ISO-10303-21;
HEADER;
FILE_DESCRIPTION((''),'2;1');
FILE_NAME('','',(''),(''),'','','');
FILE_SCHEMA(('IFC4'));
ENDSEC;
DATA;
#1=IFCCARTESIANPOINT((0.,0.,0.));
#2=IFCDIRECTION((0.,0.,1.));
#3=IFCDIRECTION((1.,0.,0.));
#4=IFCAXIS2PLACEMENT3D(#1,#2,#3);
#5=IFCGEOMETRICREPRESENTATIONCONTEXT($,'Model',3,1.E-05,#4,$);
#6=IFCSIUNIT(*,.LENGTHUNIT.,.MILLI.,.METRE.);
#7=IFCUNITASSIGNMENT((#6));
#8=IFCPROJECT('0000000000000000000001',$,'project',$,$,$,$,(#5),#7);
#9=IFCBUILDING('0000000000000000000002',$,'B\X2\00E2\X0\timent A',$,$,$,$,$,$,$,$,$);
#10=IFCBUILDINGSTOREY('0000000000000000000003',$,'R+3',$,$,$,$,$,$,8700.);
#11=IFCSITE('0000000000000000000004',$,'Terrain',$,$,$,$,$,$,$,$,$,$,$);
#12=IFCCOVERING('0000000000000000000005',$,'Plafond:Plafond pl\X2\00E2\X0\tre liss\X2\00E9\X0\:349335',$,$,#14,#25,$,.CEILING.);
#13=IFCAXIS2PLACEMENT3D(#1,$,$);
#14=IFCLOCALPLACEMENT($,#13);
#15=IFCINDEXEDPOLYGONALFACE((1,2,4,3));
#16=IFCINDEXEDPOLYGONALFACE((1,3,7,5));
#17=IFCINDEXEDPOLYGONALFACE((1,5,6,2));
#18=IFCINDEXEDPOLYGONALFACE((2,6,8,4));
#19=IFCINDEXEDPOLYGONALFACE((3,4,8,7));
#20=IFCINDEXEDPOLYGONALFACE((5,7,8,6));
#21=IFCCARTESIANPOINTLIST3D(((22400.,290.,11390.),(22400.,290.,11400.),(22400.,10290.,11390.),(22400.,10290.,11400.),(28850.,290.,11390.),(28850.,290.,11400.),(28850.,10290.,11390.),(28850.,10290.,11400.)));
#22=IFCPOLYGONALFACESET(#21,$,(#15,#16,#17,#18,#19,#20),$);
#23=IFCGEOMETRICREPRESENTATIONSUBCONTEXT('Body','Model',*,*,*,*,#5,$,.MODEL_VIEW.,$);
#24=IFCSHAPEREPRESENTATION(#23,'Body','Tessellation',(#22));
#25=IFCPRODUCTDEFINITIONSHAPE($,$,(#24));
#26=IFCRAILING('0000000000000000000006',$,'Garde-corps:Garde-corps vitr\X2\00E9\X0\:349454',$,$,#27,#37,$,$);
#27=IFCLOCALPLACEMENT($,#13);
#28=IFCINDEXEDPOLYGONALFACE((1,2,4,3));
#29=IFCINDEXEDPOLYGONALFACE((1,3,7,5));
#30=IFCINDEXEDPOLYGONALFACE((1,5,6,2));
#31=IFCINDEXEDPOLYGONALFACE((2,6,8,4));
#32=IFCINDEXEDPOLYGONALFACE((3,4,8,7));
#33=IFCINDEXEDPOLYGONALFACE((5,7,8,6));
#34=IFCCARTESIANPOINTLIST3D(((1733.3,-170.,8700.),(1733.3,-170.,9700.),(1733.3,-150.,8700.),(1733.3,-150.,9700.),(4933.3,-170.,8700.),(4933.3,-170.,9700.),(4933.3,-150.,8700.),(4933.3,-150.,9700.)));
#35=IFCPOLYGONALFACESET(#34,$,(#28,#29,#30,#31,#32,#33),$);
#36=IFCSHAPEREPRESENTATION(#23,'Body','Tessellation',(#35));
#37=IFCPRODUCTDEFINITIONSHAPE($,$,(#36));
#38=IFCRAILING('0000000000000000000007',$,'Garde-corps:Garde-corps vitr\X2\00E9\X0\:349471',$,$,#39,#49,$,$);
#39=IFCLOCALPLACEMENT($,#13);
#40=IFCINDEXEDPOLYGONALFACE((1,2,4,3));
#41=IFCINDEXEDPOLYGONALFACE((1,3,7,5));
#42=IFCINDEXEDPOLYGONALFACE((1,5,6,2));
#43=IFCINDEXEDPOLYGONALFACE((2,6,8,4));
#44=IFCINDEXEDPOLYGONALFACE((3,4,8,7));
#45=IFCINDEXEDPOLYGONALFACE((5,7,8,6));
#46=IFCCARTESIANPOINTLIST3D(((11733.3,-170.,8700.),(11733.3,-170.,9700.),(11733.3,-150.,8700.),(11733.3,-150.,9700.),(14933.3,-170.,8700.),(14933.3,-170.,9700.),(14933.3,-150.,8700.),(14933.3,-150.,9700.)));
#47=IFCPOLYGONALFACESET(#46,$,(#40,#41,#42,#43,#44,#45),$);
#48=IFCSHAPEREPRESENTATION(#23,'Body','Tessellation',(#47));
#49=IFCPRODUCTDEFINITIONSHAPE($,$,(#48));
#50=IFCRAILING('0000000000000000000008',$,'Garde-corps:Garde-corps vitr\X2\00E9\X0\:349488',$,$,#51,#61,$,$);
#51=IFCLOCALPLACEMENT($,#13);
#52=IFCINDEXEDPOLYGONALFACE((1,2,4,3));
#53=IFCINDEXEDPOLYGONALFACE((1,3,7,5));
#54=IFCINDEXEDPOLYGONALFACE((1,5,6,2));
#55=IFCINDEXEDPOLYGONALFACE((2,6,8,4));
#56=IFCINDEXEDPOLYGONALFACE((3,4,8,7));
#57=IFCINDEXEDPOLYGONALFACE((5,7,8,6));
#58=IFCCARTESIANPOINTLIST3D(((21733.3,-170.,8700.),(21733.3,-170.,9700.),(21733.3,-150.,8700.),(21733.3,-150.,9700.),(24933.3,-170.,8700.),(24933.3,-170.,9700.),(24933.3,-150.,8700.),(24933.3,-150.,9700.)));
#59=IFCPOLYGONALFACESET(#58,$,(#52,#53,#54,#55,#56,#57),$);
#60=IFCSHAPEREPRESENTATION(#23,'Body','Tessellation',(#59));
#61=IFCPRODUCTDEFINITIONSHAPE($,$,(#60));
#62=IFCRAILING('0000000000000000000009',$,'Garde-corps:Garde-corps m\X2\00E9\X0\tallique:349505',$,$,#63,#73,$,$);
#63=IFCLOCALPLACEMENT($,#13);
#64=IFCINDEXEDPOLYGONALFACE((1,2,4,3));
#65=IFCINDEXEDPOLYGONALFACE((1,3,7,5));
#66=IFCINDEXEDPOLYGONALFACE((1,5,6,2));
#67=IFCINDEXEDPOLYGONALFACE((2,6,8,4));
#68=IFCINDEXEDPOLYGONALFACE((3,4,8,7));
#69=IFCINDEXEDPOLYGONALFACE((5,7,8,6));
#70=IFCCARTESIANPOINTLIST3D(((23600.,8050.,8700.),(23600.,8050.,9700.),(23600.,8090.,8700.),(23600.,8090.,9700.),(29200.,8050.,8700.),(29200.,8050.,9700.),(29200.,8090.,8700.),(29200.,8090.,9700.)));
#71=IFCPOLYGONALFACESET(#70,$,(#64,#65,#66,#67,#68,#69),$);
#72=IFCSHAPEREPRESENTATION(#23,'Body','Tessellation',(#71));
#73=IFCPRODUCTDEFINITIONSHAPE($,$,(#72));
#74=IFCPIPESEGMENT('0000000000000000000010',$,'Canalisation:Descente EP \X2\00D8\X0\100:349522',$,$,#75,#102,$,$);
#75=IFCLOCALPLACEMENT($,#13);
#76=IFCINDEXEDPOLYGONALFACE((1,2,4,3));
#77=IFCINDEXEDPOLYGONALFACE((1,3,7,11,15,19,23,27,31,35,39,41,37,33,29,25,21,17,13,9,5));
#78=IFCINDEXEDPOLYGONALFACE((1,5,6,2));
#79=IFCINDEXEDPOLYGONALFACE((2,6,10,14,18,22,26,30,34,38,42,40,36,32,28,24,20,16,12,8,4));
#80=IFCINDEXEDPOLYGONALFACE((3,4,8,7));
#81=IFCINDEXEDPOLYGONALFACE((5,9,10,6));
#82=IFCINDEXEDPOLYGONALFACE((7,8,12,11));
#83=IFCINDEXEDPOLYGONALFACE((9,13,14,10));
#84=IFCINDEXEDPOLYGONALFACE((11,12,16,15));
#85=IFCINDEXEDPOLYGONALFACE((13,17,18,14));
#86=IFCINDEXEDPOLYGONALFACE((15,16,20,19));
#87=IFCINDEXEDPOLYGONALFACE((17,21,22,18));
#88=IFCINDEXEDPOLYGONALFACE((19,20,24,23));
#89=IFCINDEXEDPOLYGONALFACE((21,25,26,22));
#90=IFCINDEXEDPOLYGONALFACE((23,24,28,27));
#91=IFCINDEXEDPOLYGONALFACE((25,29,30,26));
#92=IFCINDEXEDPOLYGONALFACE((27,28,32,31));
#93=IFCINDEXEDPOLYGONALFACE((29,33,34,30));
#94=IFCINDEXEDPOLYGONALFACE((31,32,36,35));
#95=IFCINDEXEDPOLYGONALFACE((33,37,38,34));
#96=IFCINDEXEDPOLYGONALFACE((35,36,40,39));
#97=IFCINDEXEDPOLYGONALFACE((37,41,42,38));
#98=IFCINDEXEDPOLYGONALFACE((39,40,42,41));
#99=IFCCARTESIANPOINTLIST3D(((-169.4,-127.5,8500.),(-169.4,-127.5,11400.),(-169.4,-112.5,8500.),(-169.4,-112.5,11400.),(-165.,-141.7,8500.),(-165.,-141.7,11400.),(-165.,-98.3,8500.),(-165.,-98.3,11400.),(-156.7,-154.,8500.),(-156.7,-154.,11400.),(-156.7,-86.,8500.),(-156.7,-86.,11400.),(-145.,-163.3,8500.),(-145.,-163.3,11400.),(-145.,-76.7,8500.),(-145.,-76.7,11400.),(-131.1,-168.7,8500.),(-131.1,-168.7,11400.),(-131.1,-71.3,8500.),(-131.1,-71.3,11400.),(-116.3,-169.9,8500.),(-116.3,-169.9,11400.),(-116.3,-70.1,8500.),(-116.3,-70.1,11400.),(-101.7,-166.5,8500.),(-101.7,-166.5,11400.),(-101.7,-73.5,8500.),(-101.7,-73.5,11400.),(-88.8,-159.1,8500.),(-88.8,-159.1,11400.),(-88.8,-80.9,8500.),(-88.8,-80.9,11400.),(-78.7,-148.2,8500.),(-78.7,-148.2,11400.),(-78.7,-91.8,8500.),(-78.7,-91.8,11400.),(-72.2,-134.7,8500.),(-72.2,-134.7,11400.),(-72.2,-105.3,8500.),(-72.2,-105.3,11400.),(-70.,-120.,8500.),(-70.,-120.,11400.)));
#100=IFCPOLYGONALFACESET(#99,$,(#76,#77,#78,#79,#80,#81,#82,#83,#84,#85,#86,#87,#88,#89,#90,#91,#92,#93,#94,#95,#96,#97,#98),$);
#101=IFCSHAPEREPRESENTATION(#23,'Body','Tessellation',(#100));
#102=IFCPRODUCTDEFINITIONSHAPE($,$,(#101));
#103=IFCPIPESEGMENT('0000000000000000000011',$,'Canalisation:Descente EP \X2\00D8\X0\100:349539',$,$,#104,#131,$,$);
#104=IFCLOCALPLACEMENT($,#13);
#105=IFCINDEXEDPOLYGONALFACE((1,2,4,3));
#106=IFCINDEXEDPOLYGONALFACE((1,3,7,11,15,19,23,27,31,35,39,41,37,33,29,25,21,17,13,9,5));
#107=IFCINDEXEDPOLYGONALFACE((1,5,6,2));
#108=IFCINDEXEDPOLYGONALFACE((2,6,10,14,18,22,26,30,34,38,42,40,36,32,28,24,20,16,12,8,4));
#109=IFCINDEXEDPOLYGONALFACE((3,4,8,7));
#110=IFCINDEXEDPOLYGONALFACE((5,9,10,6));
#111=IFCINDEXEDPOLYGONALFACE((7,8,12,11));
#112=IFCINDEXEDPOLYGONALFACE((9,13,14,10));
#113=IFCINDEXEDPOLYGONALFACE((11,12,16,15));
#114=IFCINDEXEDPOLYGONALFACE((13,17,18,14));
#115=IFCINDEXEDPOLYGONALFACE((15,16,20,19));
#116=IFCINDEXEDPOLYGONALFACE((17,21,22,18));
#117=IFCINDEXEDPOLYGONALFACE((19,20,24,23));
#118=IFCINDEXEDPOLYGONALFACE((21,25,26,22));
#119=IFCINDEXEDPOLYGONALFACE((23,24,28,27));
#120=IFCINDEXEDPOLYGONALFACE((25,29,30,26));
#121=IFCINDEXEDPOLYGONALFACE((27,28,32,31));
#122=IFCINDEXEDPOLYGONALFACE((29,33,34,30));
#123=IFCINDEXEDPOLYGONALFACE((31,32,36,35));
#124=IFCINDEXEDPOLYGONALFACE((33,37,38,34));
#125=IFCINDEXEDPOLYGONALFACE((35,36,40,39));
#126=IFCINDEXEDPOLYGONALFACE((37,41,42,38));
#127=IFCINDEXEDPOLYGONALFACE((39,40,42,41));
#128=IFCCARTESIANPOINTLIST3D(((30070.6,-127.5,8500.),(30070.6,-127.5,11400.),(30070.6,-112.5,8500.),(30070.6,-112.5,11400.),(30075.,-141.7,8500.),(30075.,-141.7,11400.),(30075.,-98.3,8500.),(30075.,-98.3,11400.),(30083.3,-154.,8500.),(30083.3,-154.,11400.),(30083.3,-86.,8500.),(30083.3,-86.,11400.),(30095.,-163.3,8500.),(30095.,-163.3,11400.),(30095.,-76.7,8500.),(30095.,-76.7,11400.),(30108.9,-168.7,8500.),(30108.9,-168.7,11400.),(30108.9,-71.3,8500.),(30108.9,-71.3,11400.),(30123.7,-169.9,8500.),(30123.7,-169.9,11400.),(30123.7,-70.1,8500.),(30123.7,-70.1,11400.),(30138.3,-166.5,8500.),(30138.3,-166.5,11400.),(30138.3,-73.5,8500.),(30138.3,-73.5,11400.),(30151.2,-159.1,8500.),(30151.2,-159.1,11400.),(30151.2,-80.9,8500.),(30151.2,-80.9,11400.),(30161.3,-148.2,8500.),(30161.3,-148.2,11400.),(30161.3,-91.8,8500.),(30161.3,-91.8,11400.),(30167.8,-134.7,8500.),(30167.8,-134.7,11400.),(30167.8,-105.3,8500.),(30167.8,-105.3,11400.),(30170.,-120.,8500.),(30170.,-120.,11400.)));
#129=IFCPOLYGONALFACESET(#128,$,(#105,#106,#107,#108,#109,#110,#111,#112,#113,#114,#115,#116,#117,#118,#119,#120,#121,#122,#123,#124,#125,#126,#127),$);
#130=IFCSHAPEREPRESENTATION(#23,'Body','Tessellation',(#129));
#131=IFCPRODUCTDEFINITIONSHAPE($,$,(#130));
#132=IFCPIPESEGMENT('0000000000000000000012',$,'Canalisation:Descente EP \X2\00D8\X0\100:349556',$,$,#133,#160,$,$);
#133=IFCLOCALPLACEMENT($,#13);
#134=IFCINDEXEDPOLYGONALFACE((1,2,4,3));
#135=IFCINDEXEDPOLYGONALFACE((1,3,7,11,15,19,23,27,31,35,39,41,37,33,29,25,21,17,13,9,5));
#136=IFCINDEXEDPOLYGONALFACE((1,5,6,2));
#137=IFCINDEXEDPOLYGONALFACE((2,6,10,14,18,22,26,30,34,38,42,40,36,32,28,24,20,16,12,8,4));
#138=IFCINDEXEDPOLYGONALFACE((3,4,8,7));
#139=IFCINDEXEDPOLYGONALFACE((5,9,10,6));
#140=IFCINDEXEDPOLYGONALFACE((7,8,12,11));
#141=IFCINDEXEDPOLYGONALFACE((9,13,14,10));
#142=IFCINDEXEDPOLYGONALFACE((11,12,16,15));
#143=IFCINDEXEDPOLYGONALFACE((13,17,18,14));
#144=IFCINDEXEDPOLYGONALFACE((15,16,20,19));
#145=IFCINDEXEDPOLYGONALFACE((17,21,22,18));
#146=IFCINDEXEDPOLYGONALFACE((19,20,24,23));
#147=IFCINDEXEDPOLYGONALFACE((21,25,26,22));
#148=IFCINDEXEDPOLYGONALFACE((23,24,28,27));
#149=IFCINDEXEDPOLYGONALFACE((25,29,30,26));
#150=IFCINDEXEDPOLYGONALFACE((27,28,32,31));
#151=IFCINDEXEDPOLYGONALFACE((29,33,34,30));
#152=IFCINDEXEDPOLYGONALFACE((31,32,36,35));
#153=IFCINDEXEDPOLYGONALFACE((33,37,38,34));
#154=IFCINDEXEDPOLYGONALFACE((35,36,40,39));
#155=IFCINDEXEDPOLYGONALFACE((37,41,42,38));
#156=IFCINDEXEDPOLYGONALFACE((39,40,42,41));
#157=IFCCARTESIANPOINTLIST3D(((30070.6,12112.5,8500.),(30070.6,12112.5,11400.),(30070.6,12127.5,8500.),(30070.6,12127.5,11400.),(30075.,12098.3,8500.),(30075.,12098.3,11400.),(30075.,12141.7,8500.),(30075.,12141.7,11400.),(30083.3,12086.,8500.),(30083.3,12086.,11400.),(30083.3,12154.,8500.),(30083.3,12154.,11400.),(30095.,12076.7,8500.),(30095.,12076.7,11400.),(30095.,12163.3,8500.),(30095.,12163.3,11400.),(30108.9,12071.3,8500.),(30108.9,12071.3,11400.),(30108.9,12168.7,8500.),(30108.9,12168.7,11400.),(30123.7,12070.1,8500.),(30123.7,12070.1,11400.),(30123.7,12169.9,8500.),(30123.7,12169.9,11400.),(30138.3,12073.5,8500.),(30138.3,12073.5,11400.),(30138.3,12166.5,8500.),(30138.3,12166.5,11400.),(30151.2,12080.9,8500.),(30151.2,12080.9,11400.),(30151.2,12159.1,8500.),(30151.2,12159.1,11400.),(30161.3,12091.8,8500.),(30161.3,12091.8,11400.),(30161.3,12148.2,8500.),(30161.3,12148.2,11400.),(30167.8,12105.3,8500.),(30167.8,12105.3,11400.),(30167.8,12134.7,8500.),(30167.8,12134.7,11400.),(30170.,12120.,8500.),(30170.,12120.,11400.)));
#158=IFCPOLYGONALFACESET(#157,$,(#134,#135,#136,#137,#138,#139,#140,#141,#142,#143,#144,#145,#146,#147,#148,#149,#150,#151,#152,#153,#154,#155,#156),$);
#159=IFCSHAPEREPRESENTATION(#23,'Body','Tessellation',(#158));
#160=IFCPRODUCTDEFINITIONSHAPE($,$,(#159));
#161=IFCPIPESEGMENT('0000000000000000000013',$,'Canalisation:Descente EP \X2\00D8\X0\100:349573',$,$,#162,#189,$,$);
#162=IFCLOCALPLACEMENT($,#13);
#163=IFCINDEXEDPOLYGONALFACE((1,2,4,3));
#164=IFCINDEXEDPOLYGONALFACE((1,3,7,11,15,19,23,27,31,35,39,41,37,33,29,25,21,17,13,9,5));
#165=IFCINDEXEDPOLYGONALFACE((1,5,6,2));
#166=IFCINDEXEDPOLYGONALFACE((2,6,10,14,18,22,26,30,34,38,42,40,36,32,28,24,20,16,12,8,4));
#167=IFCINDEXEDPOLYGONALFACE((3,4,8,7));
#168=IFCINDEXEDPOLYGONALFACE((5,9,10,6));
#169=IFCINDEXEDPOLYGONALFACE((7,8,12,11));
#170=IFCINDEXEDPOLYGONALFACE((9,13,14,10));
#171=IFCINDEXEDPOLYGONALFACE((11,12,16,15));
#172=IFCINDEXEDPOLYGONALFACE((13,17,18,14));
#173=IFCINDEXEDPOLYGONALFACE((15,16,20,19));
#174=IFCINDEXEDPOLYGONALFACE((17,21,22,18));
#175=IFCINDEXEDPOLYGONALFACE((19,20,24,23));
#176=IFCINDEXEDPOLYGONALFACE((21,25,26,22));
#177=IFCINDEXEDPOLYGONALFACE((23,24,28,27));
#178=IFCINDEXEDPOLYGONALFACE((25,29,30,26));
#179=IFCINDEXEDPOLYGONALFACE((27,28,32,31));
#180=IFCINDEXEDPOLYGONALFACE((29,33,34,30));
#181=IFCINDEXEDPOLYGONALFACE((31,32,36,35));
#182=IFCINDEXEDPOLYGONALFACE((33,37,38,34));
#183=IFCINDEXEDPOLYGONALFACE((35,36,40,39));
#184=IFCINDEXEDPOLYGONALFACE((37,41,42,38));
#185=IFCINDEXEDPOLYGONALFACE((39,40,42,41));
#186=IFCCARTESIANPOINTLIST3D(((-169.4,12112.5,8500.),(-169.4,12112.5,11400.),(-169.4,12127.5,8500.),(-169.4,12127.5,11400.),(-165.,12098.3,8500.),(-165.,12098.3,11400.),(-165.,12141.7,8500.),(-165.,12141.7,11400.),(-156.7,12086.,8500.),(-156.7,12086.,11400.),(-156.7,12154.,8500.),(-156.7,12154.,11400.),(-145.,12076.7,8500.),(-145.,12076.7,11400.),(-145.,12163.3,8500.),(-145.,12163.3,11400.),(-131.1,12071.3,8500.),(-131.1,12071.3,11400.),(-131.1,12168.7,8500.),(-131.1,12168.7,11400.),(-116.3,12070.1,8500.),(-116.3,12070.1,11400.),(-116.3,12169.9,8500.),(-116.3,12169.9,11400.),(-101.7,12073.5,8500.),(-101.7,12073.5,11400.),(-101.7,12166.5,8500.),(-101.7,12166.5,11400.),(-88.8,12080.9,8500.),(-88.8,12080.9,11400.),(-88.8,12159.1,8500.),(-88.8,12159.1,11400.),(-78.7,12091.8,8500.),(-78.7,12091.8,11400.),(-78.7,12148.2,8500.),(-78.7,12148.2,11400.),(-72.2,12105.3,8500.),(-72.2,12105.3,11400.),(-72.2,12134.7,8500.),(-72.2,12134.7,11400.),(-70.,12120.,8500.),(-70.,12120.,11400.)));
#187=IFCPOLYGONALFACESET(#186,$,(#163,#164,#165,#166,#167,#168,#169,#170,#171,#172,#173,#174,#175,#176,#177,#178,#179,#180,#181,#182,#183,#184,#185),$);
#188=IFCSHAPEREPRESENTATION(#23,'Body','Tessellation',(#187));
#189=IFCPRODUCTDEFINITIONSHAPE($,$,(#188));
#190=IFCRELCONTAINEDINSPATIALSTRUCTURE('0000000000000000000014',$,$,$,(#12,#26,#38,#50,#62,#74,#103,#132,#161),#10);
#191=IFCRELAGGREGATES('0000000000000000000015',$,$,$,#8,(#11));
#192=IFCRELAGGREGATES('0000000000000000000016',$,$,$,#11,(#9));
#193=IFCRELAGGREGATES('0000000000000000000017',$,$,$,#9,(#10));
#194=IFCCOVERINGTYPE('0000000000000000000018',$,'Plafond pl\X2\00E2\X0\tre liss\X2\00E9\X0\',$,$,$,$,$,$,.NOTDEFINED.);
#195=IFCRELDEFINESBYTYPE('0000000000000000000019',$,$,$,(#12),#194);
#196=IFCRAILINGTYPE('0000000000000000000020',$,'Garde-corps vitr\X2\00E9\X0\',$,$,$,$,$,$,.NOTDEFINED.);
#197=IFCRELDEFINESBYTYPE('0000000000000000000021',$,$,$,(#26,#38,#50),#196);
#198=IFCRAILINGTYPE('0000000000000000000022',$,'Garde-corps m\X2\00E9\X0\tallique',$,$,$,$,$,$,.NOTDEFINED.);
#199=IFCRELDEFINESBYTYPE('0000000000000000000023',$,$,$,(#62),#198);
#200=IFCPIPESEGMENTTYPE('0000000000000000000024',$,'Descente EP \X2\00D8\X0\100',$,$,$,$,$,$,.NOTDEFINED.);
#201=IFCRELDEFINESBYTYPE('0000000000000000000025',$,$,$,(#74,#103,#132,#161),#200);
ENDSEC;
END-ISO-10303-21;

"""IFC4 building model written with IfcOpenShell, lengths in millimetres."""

from ifc_helpers import new_model, si_unit, frame, frame_2d, origin_with_axes, origin_2d, place, context, subcontext, project, spatial, rectangle, circle, extrude, type_object, element, save


model = new_model("IFC4")

# Units and contexts
model_context = context("Model", 3, precision=1e-05, world=origin_with_axes())
body_context = subcontext(model_context, "Body", "Model", "MODEL_VIEW")
ifc_project = project(units=[si_unit("LENGTHUNIT", "METRE", prefix="MILLI")], contexts=[model_context])

# Site, building, storey
site = spatial("IfcSite", under=ifc_project, Name="Terrain")
building = spatial("IfcBuilding", under=site, Name="Bâtiment A")
storey = spatial("IfcBuildingStorey", under=building, Name="R+3", Elevation=8700.0)

# Covering
covering_type_1 = type_object("IfcCoveringType", Name="Plafond plâtre lissé", PredefinedType="NOTDEFINED")
covering_1_placement = place(None, origin_with_axes())
element("IfcCovering", 1, at=covering_1_placement, inside=storey, type_object=covering_type_1, Name="Plafond:Plafond plâtre lissé:349335", PredefinedType="CEILING", context=body_context, shape_type="SweptSolid", body=[
    extrude(rectangle(XDim=6450.0, YDim=10000.0, at=frame_2d((25625.0, 5290.0))), frame((0.0, 0.0, 11390.0), z_axis=(0.0, 0.0, 1.0), x_axis=(1.0, 0.0, 0.0)), (0.0, 0.0, 1.0), 10.0),
])

# Railings
railing_type_1 = type_object("IfcRailingType", Name="Garde-corps vitré", PredefinedType="NOTDEFINED")
railing_1_placement = place(None, origin_with_axes())
element("IfcRailing", 2, at=railing_1_placement, inside=storey, type_object=railing_type_1, Name="Garde-corps:Garde-corps vitré:349454", context=body_context, shape_type="SweptSolid", body=[
    extrude(rectangle(XDim=3200.0, YDim=20.0, at=frame_2d((3333.3, -160.0))), frame((0.0, 0.0, 8700.0), z_axis=(0.0, 0.0, 1.0), x_axis=(1.0, 0.0, 0.0)), (0.0, 0.0, 1.0), 1000.0),
])
railing_2_placement = place(None, origin_with_axes())
element("IfcRailing", 3, at=railing_2_placement, inside=storey, type_object=railing_type_1, Name="Garde-corps:Garde-corps vitré:349471", context=body_context, shape_type="SweptSolid", body=[
    extrude(rectangle(XDim=3200.0, YDim=20.0, at=frame_2d((13333.3, -160.0))), frame((0.0, 0.0, 8700.0), z_axis=(0.0, 0.0, 1.0), x_axis=(1.0, 0.0, 0.0)), (0.0, 0.0, 1.0), 1000.0),
])
railing_3_placement = place(None, origin_with_axes())
element("IfcRailing", 4, at=railing_3_placement, inside=storey, type_object=railing_type_1, Name="Garde-corps:Garde-corps vitré:349488", context=body_context, shape_type="SweptSolid", body=[
    extrude(rectangle(XDim=3200.0, YDim=20.0, at=frame_2d((23333.3, -160.0))), frame((0.0, 0.0, 8700.0), z_axis=(0.0, 0.0, 1.0), x_axis=(1.0, 0.0, 0.0)), (0.0, 0.0, 1.0), 1000.0),
])
railing_type_2 = type_object("IfcRailingType", Name="Garde-corps métallique", PredefinedType="NOTDEFINED")
railing_4_placement = place(None, origin_with_axes())
element("IfcRailing", 5, at=railing_4_placement, inside=storey, type_object=railing_type_2, Name="Garde-corps:Garde-corps métallique:349505", context=body_context, shape_type="SweptSolid", body=[
    extrude(rectangle(XDim=5600.0, YDim=40.0, at=frame_2d((26400.0, 8070.0))), frame((0.0, 0.0, 8700.0), z_axis=(0.0, 0.0, 1.0), x_axis=(1.0, 0.0, 0.0)), (0.0, 0.0, 1.0), 1000.0),
])

# Pipe segments
pipe_segment_type = type_object("IfcPipeSegmentType", Name="Descente EP Ø100", PredefinedType="NOTDEFINED")
pipe_segment_1_placement = place(None, origin_with_axes())
element("IfcPipeSegment", 6, at=pipe_segment_1_placement, inside=storey, type_object=pipe_segment_type, Name="Canalisation:Descente EP Ø100:349522", context=body_context, shape_type="SweptSolid", body=[
    extrude(circle(Radius=50.0, at=origin_2d()), frame((-120.0, -120.0, 8500.0), z_axis=(0.0, 0.0, 1.0), x_axis=(1.0, 0.0, 0.0)), (0.0, 0.0, 1.0), 2900.0),
])
pipe_segment_2_placement = place(None, origin_with_axes())
element("IfcPipeSegment", 7, at=pipe_segment_2_placement, inside=storey, type_object=pipe_segment_type, Name="Canalisation:Descente EP Ø100:349539", context=body_context, shape_type="SweptSolid", body=[
    extrude(circle(Radius=50.0, at=origin_2d()), frame((30120.0, -120.0, 8500.0), z_axis=(0.0, 0.0, 1.0), x_axis=(1.0, 0.0, 0.0)), (0.0, 0.0, 1.0), 2900.0),
])
pipe_segment_3_placement = place(None, origin_with_axes())
element("IfcPipeSegment", 8, at=pipe_segment_3_placement, inside=storey, type_object=pipe_segment_type, Name="Canalisation:Descente EP Ø100:349556", context=body_context, shape_type="SweptSolid", body=[
    extrude(circle(Radius=50.0, at=origin_2d()), frame((30120.0, 12120.0, 8500.0), z_axis=(0.0, 0.0, 1.0), x_axis=(1.0, 0.0, 0.0)), (0.0, 0.0, 1.0), 2900.0),
])
pipe_segment_4_placement = place(None, origin_with_axes())
element("IfcPipeSegment", 9, at=pipe_segment_4_placement, inside=storey, type_object=pipe_segment_type, Name="Canalisation:Descente EP Ø100:349573", context=body_context, shape_type="SweptSolid", body=[
    extrude(circle(Radius=50.0, at=origin_2d()), frame((-120.0, 12120.0, 8500.0), z_axis=(0.0, 0.0, 1.0), x_axis=(1.0, 0.0, 0.0)), (0.0, 0.0, 1.0), 2900.0),
])

save(model, "model.ifc")
